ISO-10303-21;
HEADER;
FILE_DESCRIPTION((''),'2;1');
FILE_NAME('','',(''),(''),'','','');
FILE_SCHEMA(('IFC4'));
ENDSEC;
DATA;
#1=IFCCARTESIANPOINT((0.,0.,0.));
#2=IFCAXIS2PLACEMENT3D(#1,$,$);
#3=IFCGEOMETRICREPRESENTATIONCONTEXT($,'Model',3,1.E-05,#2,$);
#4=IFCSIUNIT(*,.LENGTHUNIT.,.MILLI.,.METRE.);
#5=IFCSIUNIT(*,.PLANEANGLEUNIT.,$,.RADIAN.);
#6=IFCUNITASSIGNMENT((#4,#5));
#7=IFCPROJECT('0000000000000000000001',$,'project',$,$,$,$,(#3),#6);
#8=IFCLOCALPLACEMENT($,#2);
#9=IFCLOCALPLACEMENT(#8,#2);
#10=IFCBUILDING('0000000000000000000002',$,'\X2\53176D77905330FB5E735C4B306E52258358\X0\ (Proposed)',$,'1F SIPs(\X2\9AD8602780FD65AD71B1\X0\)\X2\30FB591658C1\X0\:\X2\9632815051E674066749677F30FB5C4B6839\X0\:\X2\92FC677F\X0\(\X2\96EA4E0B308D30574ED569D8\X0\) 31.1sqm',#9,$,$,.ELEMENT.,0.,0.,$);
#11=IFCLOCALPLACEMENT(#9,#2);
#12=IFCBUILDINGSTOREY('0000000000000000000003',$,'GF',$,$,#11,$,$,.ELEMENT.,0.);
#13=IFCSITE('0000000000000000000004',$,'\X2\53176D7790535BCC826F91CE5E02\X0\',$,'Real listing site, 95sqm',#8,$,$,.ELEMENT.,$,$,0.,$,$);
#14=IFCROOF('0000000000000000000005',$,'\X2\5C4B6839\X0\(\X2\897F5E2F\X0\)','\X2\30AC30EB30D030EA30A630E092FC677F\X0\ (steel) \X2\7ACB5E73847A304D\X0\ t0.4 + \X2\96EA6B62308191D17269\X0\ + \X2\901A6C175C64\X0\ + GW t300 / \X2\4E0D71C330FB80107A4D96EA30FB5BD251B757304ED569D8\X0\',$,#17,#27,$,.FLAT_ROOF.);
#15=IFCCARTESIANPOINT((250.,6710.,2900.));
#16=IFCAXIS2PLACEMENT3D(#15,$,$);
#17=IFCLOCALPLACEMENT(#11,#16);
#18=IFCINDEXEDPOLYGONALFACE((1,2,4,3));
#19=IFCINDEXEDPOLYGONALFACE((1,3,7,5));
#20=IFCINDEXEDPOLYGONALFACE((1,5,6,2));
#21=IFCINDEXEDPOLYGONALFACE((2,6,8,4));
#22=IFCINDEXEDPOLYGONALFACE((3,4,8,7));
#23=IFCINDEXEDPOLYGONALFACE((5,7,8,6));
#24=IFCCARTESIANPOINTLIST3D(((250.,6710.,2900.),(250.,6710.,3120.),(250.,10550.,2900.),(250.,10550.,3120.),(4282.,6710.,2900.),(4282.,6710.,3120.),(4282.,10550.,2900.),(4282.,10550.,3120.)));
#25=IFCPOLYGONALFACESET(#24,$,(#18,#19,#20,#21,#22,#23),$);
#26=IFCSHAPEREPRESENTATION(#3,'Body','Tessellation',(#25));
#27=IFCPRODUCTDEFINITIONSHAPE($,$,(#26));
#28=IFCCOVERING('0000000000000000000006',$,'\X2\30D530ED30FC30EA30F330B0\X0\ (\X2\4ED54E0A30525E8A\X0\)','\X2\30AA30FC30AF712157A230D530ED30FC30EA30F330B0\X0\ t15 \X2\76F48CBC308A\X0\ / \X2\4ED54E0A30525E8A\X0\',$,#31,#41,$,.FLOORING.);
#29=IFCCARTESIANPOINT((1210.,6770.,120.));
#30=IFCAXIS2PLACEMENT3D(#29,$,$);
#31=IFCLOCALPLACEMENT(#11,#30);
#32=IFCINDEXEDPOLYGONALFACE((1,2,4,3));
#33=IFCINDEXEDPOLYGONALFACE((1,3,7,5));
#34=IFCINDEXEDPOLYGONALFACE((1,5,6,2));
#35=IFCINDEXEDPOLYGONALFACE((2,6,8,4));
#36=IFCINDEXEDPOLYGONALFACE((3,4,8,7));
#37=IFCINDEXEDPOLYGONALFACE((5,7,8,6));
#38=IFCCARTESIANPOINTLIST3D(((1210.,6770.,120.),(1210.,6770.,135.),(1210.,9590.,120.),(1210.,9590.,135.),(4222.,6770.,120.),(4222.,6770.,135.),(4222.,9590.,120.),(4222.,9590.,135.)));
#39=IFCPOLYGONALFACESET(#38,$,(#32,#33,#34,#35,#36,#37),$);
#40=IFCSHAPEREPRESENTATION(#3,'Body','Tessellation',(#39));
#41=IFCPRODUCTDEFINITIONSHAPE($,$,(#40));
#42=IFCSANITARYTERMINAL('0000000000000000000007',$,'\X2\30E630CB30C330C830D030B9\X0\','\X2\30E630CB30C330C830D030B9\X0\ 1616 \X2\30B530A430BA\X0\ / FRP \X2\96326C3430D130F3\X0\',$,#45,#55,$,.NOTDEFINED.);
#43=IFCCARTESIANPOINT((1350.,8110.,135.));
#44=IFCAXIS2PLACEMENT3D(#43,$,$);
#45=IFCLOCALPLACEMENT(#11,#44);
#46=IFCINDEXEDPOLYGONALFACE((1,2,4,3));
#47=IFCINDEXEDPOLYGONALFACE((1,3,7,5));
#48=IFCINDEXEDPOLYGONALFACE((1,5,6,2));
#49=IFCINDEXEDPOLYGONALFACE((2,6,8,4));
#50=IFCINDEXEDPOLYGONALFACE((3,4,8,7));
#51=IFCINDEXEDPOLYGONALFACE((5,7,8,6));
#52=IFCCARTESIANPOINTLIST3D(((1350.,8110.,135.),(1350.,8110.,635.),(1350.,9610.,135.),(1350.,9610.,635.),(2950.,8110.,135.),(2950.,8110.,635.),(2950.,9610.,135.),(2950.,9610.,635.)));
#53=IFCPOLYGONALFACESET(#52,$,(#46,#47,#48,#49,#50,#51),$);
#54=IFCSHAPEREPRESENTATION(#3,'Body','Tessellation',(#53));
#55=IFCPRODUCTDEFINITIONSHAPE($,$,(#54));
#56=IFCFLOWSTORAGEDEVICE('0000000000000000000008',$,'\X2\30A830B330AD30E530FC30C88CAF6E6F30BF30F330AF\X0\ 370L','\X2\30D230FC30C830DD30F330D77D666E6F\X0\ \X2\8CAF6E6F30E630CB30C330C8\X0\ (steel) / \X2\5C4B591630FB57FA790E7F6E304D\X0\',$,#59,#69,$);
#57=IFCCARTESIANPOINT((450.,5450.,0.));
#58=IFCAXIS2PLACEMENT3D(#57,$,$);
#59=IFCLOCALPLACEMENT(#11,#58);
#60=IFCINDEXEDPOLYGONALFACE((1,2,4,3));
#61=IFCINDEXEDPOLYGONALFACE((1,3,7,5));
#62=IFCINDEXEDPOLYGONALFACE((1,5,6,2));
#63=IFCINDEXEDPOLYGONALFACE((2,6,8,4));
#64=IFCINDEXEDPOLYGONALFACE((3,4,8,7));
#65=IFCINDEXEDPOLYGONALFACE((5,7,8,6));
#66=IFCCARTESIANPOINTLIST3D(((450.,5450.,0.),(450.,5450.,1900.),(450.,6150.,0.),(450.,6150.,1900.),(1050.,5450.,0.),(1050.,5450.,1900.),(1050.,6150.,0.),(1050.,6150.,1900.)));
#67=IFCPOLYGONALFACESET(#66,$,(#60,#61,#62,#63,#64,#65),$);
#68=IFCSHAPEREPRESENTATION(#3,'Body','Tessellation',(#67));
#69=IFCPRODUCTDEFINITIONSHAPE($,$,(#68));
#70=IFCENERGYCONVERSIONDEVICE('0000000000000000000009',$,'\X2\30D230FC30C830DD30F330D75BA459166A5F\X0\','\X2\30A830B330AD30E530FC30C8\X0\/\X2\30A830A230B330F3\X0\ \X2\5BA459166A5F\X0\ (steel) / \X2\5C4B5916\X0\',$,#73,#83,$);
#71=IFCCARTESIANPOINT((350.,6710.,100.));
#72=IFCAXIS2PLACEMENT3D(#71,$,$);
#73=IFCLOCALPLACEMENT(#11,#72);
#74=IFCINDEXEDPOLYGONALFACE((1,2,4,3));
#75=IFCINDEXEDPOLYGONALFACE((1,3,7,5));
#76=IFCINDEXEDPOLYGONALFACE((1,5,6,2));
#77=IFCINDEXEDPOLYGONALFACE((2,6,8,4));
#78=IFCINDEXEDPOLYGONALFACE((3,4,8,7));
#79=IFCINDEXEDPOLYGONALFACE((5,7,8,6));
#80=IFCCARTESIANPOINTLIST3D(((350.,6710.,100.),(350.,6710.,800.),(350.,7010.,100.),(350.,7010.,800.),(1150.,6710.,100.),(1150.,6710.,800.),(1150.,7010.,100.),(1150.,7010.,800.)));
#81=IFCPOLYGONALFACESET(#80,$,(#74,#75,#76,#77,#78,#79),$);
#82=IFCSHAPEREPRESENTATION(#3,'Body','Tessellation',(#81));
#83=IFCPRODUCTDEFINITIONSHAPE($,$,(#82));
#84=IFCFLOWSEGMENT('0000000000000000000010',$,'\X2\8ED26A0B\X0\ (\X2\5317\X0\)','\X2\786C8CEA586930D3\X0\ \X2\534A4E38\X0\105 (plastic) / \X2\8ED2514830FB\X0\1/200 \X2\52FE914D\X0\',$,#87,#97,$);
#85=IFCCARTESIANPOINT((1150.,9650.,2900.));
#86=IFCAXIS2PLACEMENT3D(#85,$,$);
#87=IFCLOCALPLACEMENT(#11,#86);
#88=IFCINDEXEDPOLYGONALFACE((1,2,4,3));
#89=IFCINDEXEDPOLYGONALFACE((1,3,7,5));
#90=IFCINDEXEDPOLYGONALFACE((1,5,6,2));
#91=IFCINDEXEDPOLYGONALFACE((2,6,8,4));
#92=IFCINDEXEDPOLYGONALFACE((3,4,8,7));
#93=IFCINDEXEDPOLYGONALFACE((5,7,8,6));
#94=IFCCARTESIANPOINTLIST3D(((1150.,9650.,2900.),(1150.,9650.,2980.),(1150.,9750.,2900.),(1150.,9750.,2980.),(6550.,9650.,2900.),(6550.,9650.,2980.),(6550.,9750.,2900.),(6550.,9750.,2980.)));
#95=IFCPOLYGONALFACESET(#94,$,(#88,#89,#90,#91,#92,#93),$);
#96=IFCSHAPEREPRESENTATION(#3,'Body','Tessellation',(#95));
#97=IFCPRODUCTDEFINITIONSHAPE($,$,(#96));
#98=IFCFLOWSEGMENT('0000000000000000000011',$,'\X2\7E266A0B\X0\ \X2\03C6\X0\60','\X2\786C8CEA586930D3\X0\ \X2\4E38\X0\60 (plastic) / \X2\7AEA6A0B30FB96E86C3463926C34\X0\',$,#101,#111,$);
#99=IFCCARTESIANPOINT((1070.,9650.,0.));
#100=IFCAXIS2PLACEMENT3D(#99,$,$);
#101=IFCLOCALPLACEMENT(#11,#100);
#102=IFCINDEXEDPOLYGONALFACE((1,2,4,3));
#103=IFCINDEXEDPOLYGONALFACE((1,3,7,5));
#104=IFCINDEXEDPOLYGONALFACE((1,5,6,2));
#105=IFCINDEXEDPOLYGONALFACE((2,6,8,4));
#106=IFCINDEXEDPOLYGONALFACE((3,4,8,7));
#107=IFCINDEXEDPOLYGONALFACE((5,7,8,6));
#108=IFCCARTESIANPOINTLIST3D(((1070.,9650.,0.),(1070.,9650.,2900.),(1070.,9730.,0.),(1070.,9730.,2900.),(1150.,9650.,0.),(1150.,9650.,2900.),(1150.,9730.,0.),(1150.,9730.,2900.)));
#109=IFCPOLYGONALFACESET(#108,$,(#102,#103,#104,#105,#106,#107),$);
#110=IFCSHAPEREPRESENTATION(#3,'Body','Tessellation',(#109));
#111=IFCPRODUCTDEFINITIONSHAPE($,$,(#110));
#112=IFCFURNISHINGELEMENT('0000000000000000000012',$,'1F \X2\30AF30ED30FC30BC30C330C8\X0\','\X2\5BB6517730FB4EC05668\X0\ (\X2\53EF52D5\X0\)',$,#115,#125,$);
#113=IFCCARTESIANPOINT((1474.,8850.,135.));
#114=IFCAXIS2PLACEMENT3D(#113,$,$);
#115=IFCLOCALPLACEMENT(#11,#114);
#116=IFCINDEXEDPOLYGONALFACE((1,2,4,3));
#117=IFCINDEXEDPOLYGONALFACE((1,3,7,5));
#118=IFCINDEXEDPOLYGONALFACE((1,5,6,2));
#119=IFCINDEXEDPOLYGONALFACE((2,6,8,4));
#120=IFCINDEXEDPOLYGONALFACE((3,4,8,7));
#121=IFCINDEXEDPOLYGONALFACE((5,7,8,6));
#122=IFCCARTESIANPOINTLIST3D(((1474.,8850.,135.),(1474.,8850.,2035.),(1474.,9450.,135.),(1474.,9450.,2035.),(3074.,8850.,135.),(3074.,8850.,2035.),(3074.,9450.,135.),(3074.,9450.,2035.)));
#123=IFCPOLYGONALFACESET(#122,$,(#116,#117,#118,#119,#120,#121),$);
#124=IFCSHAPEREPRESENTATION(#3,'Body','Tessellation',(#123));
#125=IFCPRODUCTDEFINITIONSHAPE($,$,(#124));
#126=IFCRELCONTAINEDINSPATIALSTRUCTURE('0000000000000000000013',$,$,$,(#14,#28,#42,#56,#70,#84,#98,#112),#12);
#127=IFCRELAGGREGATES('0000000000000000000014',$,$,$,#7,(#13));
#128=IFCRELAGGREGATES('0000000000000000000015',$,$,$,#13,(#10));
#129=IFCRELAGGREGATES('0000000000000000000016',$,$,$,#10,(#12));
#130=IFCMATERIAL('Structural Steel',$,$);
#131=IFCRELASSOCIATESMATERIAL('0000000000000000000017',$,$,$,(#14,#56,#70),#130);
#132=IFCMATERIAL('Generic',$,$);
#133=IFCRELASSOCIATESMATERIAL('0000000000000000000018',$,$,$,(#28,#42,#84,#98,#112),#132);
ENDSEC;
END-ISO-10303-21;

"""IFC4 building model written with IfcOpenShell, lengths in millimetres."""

from ifc_helpers import new_model, si_unit, frame, frame_2d, origin, place, context, project, spatial, rectangle, extrude, material, element, save


model = new_model("IFC4")

# Units and contexts
model_context = context("Model", 3, precision=1e-05, world=origin())
ifc_project = project(units=[si_unit("LENGTHUNIT", "METRE", prefix="MILLI"), si_unit("PLANEANGLEUNIT", "RADIAN")], contexts=[model_context])

# Site, building, storey
site_placement = place(None, origin())
site = spatial("IfcSite", under=ifc_project, at=site_placement, Name="北海道富良野市", ObjectType="Real listing site, 95sqm", CompositionType="ELEMENT", RefElevation=0.0)
building_placement = place(site_placement, origin())
building = spatial("IfcBuilding", under=site, at=building_placement, Name="北海道・平屋の別荘 (Proposed)", ObjectType="1F SIPs(高性能断熱)・外壁:防腐処理杉板・屋根:鋼板(雪下ろし仕様) 31.1sqm", CompositionType="ELEMENT", ElevationOfRefHeight=0.0, ElevationOfTerrain=0.0)
storey_placement = place(building_placement, origin())
storey = spatial("IfcBuildingStorey", under=building, at=storey_placement, Name="GF", CompositionType="ELEMENT", Elevation=0.0)

# Roof
ifc_material_1 = material(Name="Structural Steel")
roof_placement = place(storey_placement, frame((250.0, 6710.0, 2900.0)))
element("IfcRoof", 1, at=roof_placement, inside=storey, material=ifc_material_1, Name="屋根(西帯)", Description="ガルバリウム鋼板 (steel) 立平葺き t0.4 + 雪止め金物 + 通気層 + GW t300 / 不燃・耐積雪・寒冷地仕様", PredefinedType="FLAT_ROOF", context=model_context, shape_type="SweptSolid", body=[
    extrude(rectangle(XDim=4032.0, YDim=3840.0, at=frame_2d((2016.0, 1920.0))), frame((250.0, 6710.0, 2900.0)), (0.0, 0.0, 1.0), 220.0),
])

# Covering
ifc_material_2 = material(Name="Generic")
covering_placement = place(storey_placement, frame((1210.0, 6770.0, 120.0)))
element("IfcCovering", 2, at=covering_placement, inside=storey, material=ifc_material_2, Name="フローリング (仕上げ床)", Description="オーク無垢フローリング t15 直貼り / 仕上げ床", PredefinedType="FLOORING", context=model_context, shape_type="SweptSolid", body=[
    extrude(rectangle(XDim=3012.0, YDim=2820.0, at=frame_2d((1506.0, 1410.0))), frame((1210.0, 6770.0, 120.0)), (0.0, 0.0, 1.0), 15.0),
])

# Sanitary terminal
sanitary_terminal_placement = place(storey_placement, frame((1350.0, 8110.0, 135.0)))
element("IfcSanitaryTerminal", 3, at=sanitary_terminal_placement, inside=storey, material=ifc_material_2, Name="ユニットバス", Description="ユニットバス 1616 サイズ / FRP 防水パン", PredefinedType="NOTDEFINED", context=model_context, shape_type="SweptSolid", body=[
    extrude(rectangle(XDim=1600.0, YDim=1500.0, at=frame_2d((800.0, 750.0))), frame((1350.0, 8110.0, 135.0)), (0.0, 0.0, 1.0), 500.0),
])

# Flow storage device
flow_storage_device_placement = place(storey_placement, frame((450.0, 5450.0, 0.0)))
element("IfcFlowStorageDevice", 4, at=flow_storage_device_placement, inside=storey, material=ifc_material_1, Name="エコキュート貯湯タンク 370L", Description="ヒートポンプ給湯 貯湯ユニット (steel) / 屋外・基礎置き", context=model_context, shape_type="SweptSolid", body=[
    extrude(rectangle(XDim=600.0, YDim=700.0, at=frame_2d((300.0, 350.0))), frame((450.0, 5450.0, 0.0)), (0.0, 0.0, 1.0), 1900.0),
])

# Energy conversion device
energy_conversion_device_placement = place(storey_placement, frame((350.0, 6710.0, 100.0)))
element("IfcEnergyConversionDevice", 5, at=energy_conversion_device_placement, inside=storey, material=ifc_material_1, Name="ヒートポンプ室外機", Description="エコキュート/エアコン 室外機 (steel) / 屋外", context=model_context, shape_type="SweptSolid", body=[
    extrude(rectangle(XDim=800.0, YDim=300.0, at=frame_2d((400.0, 150.0))), frame((350.0, 6710.0, 100.0)), (0.0, 0.0, 1.0), 700.0),
])

# Flow segments
flow_segment_1_placement = place(storey_placement, frame((1150.0, 9650.0, 2900.0)))
element("IfcFlowSegment", 6, at=flow_segment_1_placement, inside=storey, material=ifc_material_2, Name="軒樋 (北)", Description="硬質塩ビ 半丸105 (plastic) / 軒先・1/200 勾配", context=model_context, shape_type="SweptSolid", body=[
    extrude(rectangle(XDim=5400.0, YDim=100.0, at=frame_2d((2700.0, 50.0))), frame((1150.0, 9650.0, 2900.0)), (0.0, 0.0, 1.0), 80.0),
])
flow_segment_2_placement = place(storey_placement, frame((1070.0, 9650.0, 0.0)))
element("IfcFlowSegment", 7, at=flow_segment_2_placement, inside=storey, material=ifc_material_2, Name="縦樋 φ60", Description="硬質塩ビ 丸60 (plastic) / 竪樋・雨水排水", context=model_context, shape_type="SweptSolid", body=[
    extrude(rectangle(XDim=80.0, YDim=80.0, at=frame_2d((40.0, 40.0))), frame((1070.0, 9650.0, 0.0)), (0.0, 0.0, 1.0), 2900.0),
])

# Furnishing element
furnishing_placement = place(storey_placement, frame((1474.0, 8850.0, 135.0)))
element("IfcFurnishingElement", 8, at=furnishing_placement, inside=storey, material=ifc_material_2, Name="1F クローゼット", Description="家具・什器 (可動)", context=model_context, shape_type="SweptSolid", body=[
    extrude(rectangle(XDim=1600.0, YDim=600.0, at=frame_2d((800.0, 300.0))), frame((1474.0, 8850.0, 135.0)), (0.0, 0.0, 1.0), 1900.0),
])

save(model, "model.ifc")
